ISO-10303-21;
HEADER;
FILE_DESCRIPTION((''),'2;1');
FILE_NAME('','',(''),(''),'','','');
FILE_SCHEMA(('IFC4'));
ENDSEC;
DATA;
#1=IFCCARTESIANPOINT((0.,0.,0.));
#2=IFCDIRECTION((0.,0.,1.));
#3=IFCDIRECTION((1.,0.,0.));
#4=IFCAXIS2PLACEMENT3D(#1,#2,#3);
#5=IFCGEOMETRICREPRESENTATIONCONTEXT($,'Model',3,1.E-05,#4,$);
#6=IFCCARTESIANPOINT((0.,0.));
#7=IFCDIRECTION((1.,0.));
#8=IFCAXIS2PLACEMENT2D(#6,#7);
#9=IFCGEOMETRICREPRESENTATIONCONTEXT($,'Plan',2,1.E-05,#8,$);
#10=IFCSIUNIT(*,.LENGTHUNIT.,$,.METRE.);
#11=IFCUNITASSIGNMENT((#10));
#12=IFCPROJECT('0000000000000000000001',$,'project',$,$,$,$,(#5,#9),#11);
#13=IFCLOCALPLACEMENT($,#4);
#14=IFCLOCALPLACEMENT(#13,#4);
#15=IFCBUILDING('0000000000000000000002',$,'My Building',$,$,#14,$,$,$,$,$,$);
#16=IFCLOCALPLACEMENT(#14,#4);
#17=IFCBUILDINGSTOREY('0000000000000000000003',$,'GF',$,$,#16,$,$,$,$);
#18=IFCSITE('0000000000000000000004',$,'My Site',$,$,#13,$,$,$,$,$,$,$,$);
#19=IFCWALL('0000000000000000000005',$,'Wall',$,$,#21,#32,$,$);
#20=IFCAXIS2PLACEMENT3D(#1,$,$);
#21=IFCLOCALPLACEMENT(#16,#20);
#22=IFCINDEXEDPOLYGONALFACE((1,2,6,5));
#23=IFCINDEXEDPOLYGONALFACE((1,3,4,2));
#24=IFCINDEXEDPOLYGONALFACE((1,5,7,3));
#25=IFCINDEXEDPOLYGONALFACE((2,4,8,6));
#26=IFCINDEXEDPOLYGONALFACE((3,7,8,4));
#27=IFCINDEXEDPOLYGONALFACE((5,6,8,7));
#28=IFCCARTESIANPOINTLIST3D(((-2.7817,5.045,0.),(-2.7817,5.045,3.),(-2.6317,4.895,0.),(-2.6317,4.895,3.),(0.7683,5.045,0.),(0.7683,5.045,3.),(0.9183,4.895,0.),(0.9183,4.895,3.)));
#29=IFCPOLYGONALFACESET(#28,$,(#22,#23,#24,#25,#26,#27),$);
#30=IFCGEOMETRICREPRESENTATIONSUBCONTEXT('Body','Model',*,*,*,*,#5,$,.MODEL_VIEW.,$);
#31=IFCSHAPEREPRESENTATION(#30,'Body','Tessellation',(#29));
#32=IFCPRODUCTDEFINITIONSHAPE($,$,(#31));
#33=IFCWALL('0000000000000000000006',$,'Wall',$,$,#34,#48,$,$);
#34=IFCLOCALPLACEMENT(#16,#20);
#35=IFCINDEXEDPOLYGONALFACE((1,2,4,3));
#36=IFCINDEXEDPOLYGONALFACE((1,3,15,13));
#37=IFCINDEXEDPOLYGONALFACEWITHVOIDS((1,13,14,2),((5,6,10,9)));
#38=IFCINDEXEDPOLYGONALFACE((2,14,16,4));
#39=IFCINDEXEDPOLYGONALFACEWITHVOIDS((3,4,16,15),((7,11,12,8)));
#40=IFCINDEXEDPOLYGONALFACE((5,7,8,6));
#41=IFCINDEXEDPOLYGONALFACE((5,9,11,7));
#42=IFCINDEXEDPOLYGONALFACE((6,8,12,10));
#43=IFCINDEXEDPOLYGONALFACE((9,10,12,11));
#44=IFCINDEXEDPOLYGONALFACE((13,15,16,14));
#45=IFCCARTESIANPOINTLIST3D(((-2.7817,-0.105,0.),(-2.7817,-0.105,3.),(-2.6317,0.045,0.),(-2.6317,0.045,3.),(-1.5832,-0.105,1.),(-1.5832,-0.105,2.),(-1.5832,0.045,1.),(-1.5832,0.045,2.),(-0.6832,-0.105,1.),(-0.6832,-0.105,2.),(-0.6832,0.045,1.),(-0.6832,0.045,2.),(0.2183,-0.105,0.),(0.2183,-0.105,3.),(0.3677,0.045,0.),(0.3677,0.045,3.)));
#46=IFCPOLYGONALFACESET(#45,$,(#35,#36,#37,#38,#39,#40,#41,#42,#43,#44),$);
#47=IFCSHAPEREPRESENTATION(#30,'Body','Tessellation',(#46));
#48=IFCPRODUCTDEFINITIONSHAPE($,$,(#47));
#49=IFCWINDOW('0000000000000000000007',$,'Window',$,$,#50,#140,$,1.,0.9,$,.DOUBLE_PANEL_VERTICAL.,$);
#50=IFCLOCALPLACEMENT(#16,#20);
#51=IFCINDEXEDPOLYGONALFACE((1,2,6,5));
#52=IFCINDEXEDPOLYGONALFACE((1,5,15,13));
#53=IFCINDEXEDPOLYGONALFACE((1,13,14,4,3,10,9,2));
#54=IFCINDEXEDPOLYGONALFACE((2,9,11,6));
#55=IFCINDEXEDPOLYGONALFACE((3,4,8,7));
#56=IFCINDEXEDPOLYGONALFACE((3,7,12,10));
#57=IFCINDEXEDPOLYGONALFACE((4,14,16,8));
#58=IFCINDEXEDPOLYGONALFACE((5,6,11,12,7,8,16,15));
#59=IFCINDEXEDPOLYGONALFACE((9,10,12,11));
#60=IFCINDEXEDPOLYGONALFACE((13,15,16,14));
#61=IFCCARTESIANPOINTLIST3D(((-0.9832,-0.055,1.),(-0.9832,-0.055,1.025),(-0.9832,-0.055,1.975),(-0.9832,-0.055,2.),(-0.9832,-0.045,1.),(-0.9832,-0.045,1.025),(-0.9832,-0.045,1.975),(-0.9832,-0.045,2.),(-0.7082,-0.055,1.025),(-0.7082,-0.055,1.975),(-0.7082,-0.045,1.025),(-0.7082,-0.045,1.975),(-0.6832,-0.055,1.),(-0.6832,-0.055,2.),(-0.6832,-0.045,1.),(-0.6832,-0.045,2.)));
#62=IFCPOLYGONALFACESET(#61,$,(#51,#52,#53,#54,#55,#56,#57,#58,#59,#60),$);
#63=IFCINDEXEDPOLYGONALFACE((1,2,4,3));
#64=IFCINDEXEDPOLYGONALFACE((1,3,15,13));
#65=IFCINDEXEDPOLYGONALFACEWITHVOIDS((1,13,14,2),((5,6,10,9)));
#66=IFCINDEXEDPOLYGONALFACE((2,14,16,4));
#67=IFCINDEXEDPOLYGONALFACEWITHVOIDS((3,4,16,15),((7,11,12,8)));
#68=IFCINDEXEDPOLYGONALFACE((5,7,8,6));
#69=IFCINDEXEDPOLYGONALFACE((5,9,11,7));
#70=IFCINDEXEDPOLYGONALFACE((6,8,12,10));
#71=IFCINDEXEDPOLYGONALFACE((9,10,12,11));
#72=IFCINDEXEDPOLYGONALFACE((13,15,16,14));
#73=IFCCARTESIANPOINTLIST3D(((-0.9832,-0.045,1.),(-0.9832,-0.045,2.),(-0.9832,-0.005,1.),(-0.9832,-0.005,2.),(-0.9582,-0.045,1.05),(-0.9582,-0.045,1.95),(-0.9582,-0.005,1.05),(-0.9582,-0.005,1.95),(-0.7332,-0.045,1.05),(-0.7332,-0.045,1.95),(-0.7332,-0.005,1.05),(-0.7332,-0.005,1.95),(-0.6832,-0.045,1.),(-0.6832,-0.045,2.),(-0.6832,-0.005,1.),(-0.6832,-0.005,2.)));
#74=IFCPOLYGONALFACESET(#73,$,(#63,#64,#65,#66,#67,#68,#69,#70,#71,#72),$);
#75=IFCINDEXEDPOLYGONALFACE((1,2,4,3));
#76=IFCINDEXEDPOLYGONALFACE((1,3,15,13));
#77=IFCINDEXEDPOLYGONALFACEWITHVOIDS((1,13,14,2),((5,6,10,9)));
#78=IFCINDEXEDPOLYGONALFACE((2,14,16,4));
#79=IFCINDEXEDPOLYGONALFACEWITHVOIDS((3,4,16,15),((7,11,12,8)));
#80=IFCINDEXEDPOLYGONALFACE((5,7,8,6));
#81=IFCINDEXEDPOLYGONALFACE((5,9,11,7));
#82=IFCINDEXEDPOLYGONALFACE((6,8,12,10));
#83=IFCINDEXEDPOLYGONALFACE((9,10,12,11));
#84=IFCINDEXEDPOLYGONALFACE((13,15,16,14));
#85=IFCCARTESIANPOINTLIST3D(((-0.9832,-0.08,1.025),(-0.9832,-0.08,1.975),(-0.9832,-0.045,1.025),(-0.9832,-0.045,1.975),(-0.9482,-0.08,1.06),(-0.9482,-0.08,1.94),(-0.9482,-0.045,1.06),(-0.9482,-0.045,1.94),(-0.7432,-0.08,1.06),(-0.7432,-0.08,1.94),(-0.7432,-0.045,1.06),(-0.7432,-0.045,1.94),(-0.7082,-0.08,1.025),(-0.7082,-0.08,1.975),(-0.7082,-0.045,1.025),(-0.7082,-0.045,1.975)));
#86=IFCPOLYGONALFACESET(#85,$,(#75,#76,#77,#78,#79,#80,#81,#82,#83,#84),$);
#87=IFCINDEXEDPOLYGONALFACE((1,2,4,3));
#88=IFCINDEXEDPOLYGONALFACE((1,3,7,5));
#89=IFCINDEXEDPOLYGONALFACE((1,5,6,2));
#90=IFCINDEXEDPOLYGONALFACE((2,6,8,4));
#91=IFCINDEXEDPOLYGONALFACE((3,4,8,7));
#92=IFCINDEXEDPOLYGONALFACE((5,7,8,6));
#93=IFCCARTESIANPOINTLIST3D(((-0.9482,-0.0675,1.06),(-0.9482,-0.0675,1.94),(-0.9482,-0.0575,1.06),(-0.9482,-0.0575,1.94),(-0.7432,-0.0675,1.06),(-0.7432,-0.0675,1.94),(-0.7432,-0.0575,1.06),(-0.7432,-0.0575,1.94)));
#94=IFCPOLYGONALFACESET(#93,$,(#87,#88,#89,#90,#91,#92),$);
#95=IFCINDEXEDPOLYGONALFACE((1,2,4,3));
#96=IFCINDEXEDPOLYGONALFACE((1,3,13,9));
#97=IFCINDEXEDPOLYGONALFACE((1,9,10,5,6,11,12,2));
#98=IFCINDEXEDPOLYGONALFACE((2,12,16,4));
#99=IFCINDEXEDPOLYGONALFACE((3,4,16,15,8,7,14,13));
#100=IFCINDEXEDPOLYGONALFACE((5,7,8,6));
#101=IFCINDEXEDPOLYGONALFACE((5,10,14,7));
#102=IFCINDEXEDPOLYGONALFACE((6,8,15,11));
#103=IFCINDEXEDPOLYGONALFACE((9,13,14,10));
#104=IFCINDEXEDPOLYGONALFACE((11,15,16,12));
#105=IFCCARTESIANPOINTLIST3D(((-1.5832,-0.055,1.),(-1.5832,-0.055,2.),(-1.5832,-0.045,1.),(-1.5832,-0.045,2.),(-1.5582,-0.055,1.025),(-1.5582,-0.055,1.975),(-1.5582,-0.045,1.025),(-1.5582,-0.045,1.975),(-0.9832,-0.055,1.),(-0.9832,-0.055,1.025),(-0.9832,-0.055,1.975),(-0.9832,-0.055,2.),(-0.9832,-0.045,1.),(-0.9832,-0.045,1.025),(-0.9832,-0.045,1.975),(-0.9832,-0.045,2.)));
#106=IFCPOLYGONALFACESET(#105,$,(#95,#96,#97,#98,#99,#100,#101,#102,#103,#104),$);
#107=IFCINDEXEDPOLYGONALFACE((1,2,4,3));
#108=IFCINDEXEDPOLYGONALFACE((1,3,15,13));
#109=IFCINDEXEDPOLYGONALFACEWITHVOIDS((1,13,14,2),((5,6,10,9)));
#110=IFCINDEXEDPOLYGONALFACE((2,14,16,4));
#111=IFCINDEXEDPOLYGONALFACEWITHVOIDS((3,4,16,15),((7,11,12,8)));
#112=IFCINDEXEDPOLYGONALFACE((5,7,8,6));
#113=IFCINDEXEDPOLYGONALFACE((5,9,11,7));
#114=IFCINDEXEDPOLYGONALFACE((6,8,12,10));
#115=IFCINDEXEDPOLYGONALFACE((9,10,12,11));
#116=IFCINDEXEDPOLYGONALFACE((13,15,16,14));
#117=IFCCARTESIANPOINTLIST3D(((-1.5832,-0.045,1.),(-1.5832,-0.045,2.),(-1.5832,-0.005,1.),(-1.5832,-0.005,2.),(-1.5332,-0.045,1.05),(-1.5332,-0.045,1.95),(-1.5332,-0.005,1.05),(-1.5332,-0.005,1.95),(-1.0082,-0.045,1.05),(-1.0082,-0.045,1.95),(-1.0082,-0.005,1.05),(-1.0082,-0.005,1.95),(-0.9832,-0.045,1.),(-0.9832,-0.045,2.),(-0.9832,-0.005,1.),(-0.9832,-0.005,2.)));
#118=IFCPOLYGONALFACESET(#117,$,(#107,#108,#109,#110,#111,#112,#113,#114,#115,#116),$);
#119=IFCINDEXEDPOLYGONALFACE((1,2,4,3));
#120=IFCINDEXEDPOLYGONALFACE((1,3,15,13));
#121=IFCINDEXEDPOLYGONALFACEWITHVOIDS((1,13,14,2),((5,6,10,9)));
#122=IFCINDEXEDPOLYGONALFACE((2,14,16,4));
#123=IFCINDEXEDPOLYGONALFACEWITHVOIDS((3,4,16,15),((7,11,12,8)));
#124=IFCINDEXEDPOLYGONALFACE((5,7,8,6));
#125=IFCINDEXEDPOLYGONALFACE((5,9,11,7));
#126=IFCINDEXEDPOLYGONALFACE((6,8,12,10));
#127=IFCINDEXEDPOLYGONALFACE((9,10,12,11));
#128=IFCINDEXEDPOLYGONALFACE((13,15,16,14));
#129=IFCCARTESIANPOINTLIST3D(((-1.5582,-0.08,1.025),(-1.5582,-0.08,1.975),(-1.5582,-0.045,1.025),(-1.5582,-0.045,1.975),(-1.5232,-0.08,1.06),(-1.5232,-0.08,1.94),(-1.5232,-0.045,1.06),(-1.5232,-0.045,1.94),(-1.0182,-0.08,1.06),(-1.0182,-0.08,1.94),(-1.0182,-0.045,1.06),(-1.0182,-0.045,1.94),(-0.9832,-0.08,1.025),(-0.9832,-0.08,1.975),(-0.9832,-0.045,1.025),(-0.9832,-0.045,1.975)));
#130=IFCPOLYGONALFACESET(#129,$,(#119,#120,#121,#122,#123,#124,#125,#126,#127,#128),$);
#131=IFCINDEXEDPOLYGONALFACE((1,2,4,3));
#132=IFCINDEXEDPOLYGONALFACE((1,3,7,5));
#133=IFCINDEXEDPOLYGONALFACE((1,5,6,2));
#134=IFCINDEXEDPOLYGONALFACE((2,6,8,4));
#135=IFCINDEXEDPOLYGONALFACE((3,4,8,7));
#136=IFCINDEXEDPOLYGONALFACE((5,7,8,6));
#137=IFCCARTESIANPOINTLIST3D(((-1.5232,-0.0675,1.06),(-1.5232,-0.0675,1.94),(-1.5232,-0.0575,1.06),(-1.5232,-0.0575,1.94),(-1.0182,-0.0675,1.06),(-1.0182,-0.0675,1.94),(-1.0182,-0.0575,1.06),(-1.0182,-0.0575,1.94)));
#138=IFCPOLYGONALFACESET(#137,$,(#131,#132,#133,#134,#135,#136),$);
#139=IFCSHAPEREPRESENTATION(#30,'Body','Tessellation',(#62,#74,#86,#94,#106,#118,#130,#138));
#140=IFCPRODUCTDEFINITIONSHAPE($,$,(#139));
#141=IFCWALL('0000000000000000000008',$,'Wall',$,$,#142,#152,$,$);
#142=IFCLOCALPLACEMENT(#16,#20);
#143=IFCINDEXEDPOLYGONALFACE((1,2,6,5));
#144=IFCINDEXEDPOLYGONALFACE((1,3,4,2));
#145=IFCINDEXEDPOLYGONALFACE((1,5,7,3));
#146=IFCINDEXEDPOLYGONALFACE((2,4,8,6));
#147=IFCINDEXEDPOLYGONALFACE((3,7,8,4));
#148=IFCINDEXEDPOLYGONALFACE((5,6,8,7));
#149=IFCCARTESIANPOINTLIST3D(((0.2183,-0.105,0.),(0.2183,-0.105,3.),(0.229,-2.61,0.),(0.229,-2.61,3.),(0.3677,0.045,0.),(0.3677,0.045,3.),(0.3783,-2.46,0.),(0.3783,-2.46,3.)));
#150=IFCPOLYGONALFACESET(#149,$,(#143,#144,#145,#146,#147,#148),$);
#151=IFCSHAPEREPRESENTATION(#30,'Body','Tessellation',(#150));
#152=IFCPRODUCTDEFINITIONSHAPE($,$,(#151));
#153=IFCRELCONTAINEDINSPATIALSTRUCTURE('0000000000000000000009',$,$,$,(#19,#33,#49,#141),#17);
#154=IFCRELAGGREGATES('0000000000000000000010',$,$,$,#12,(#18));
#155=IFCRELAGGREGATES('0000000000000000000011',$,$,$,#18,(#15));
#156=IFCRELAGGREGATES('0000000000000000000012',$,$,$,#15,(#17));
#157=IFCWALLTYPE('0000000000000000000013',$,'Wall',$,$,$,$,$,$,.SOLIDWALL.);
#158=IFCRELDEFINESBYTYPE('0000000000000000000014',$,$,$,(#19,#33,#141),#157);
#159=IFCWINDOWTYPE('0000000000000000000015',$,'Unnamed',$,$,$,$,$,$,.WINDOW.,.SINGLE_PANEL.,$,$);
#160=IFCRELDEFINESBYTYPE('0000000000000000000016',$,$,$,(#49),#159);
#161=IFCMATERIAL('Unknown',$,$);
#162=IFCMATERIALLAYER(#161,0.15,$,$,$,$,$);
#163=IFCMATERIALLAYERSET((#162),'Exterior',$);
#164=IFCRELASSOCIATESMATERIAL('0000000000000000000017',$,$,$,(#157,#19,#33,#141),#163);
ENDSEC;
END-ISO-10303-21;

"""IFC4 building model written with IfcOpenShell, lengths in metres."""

from ifc_helpers import new_model, entity, si_unit, frame, origin_with_axes, origin_2d_with_axis, place, context, subcontext, project, spatial, line, indexed_curve, outline, extrude, shape, source, transform, mapped, material, layer, layer_set, layer_usage, type_object, type_shapes, element, fill, save


model = new_model("IFC4")

# Units and contexts
model_context = context("Model", 3, precision=1e-05, world=origin_with_axes())
plan_context = context("Plan", 2, precision=1e-05, world=origin_2d_with_axis())
body_context_1 = subcontext(model_context, "Body", "Model", "MODEL_VIEW")
body_context_2 = subcontext(plan_context, "Body", "Plan", "PLAN_VIEW")
ifc_project = project(units=[si_unit("LENGTHUNIT", "METRE")], contexts=[model_context, plan_context])

# Site, building, storey
site_placement = place(None, origin_with_axes())
site = spatial("IfcSite", under=ifc_project, at=site_placement, Name="My Site")
building_placement = place(site_placement, origin_with_axes())
building = spatial("IfcBuilding", under=site, at=building_placement, Name="My Building")
storey_placement = place(building_placement, origin_with_axes())
storey = spatial("IfcBuildingStorey", under=building, at=storey_placement, Name="GF")

# Shared definitions
ifc_material = material(Name="Unknown")

# Shared definitions
ifc_layer_1 = layer(ifc_material, 0.15)
ifc_layer_set_1 = layer_set([ifc_layer_1], Name="Exterior")
wall_type_1 = type_object("IfcWallType", Name="Wall", PredefinedType="SOLIDWALL", material=ifc_layer_set_1)

# Wall
ifc_layer_usage_1 = layer_usage(ifc_layer_set_1, "AXIS2", "POSITIVE", 0.0)
wall_1_placement = place(storey_placement, frame((0.7683, 5.045, 0.0), z_axis=(0.0, 0.0, 1.0), x_axis=(-1.0, 0.0, 0.0)))
element("IfcWall", 1, at=wall_1_placement, inside=storey, type_object=wall_type_1, material=ifc_layer_usage_1, Name="Wall", context=body_context_1, shape_type="SweptSolid", body=[
    extrude(outline(indexed_curve([(0.0, 0.0), (-0.15, 0.15), (3.4, 0.15), (3.55, 0.0)], segments=[line(1, 2, 3, 4, 1)])), origin_with_axes(), (0.0, 0.0, 1.0), 3.0),
])

# Shared definitions
shared_shape_1 = source(origin_with_axes(), body_context_1, "Body", "SweptSolid", [
    extrude(outline(indexed_curve([(0.0, 0.0), (0.9, 0.0), (0.9, 1.0), (0.0, 1.0)], segments=[line(1, 2, 3, 4, 1)])), frame((0.0, -0.6, 0.0), z_axis=(0.0, -1.0, 0.0), x_axis=(1.0, 0.0, 0.0)), (0.0, 0.0, -1.0), 1.2),
])
window_type = type_object("IfcWindowType", Name="Unnamed", PartitioningType="SINGLE_PANEL", PredefinedType="WINDOW")
shared_shape_2 = source(origin_with_axes(), body_context_1, "Body", "SweptSolid", [
    extrude(outline(indexed_curve([(0.3, 0.0), (0.0, 0.0), (0.0, 1.0), (0.3, 1.0), (0.3, 0.975), (0.025, 0.975), (0.025, 0.025), (0.3, 0.025)], segments=[line(1, 2, 3, 4, 5, 6, 7, 8, 1)])), frame((0.0, 0.09, 0.0), z_axis=(0.0, -1.0, 0.0), x_axis=(1.0, 0.0, 0.0)), (0.0, 0.0, -1.0), 0.01),
    extrude(outline(indexed_curve([(0.0, 0.0), (0.3, 0.0), (0.3, 1.0), (0.0, 1.0)], segments=[line(1, 2, 3, 4, 1)]), holes=[indexed_curve([(0.05, 0.05), (0.275, 0.05), (0.275, 0.95), (0.05, 0.95)], segments=[line(1, 2, 3, 4, 1)])]), frame((0.0, 0.05, 0.0), z_axis=(0.0, -1.0, 0.0), x_axis=(1.0, 0.0, 0.0)), (0.0, 0.0, -1.0), 0.04),
    extrude(outline(indexed_curve([(0.0, 0.0), (0.275, 0.0), (0.275, 0.95), (0.0, 0.95)], segments=[line(1, 2, 3, 4, 1)]), holes=[indexed_curve([(0.035, 0.035), (0.24, 0.035), (0.24, 0.915), (0.035, 0.915)], segments=[line(1, 2, 3, 4, 1)])]), frame((0.025, 0.09, 0.025), z_axis=(0.0, -1.0, 0.0), x_axis=(1.0, 0.0, 0.0)), (0.0, 0.0, -1.0), 0.035),
    extrude(outline(indexed_curve([(0.035, 0.035), (0.24, 0.035), (0.24, 0.915), (0.035, 0.915)], segments=[line(1, 2, 3, 4, 1)])), frame((0.025, 0.1025, 0.025), z_axis=(0.0, -1.0, 0.0), x_axis=(1.0, 0.0, 0.0)), (0.0, 0.0, -1.0), 0.01),
    extrude(outline(indexed_curve([(0.0, 1.0), (0.6, 1.0), (0.6, 0.0), (0.0, 0.0), (0.0, 0.025), (0.575, 0.025), (0.575, 0.975), (0.0, 0.975)], segments=[line(1, 2, 3, 4, 5, 6, 7, 8, 1)])), frame((0.3, 0.09, 0.0), z_axis=(0.0, -1.0, 0.0), x_axis=(1.0, 0.0, 0.0)), (0.0, 0.0, -1.0), 0.01),
    extrude(outline(indexed_curve([(0.0, 0.0), (0.6, 0.0), (0.6, 1.0), (0.0, 1.0)], segments=[line(1, 2, 3, 4, 1)]), holes=[indexed_curve([(0.025, 0.05), (0.55, 0.05), (0.55, 0.95), (0.025, 0.95)], segments=[line(1, 2, 3, 4, 1)])]), frame((0.3, 0.05, 0.0), z_axis=(0.0, -1.0, 0.0), x_axis=(1.0, 0.0, 0.0)), (0.0, 0.0, -1.0), 0.04),
    extrude(outline(indexed_curve([(0.0, 0.0), (0.575, 0.0), (0.575, 0.95), (0.0, 0.95)], segments=[line(1, 2, 3, 4, 1)]), holes=[indexed_curve([(0.035, 0.035), (0.54, 0.035), (0.54, 0.915), (0.035, 0.915)], segments=[line(1, 2, 3, 4, 1)])]), frame((0.3, 0.09, 0.025), z_axis=(0.0, -1.0, 0.0), x_axis=(1.0, 0.0, 0.0)), (0.0, 0.0, -1.0), 0.035),
    extrude(outline(indexed_curve([(0.035, 0.035), (0.54, 0.035), (0.54, 0.915), (0.035, 0.915)], segments=[line(1, 2, 3, 4, 1)])), frame((0.3, 0.1025, 0.025), z_axis=(0.0, -1.0, 0.0), x_axis=(1.0, 0.0, 0.0)), (0.0, 0.0, -1.0), 0.01),
])
shared_shape_3 = source(origin_with_axes(), body_context_2, "Body", "Curve2D", [
    entity("IfcIndexedPolyCurve", entity("IfcCartesianPointList2D", [[0.05, 0.05], [0.275, 0.05]])),
    entity("IfcIndexedPolyCurve", entity("IfcCartesianPointList2D", [[0.0, 0.1], [0.025, 0.1], [0.025, 0.09], [0.05, 0.09], [0.05, 0.05], [0.0, 0.05]]), [entity("IfcLineIndex", [1, 2, 3, 4, 5, 6, 1])]),
    entity("IfcIndexedPolyCurve", entity("IfcCartesianPointList2D", [[0.3, 0.1], [0.3, 0.1], [0.3, 0.09], [0.275, 0.09], [0.275, 0.05], [0.3, 0.05]])),
    entity("IfcIndexedPolyCurve", entity("IfcCartesianPointList2D", [[0.025, 0.09], [0.06, 0.09], [0.06, 0.125], [0.025, 0.125]]), [entity("IfcLineIndex", [1, 2, 3, 4, 1])]),
    entity("IfcIndexedPolyCurve", entity("IfcCartesianPointList2D", [[0.3, 0.09], [0.265, 0.09], [0.265, 0.125], [0.3, 0.125]]), [entity("IfcLineIndex", [1, 2, 3, 4, 1])]),
    entity("IfcIndexedPolyCurve", entity("IfcCartesianPointList2D", [[0.06, 0.09], [0.265, 0.09]])),
    entity("IfcIndexedPolyCurve", entity("IfcCartesianPointList2D", [[0.06, 0.125], [0.265, 0.125]])),
    entity("IfcIndexedPolyCurve", entity("IfcCartesianPointList2D", [[0.06, 0.1075], [0.265, 0.1075]])),
    entity("IfcIndexedPolyCurve", entity("IfcCartesianPointList2D", [[0.325, 0.05], [0.85, 0.05]])),
    entity("IfcIndexedPolyCurve", entity("IfcCartesianPointList2D", [[0.3, 0.1], [0.3, 0.1], [0.3, 0.09], [0.325, 0.09], [0.325, 0.05], [0.3, 0.05]])),
    entity("IfcIndexedPolyCurve", entity("IfcCartesianPointList2D", [[0.9, 0.1], [0.875, 0.1], [0.875, 0.09], [0.85, 0.09], [0.85, 0.05], [0.9, 0.05]]), [entity("IfcLineIndex", [1, 2, 3, 4, 5, 6, 1])]),
    entity("IfcIndexedPolyCurve", entity("IfcCartesianPointList2D", [[0.3, 0.09], [0.335, 0.09], [0.335, 0.125], [0.3, 0.125]]), [entity("IfcLineIndex", [1, 2, 3, 4, 1])]),
    entity("IfcIndexedPolyCurve", entity("IfcCartesianPointList2D", [[0.875, 0.09], [0.84, 0.09], [0.84, 0.125], [0.875, 0.125]]), [entity("IfcLineIndex", [1, 2, 3, 4, 1])]),
    entity("IfcIndexedPolyCurve", entity("IfcCartesianPointList2D", [[0.335, 0.09], [0.84, 0.09]])),
    entity("IfcIndexedPolyCurve", entity("IfcCartesianPointList2D", [[0.335, 0.125], [0.84, 0.125]])),
    entity("IfcIndexedPolyCurve", entity("IfcCartesianPointList2D", [[0.335, 0.1075], [0.84, 0.1075]])),
])
type_shapes(window_type, [shared_shape_2, shared_shape_3])

# Wall, opening, window
ifc_layer_usage_2 = layer_usage(ifc_layer_set_1, "AXIS2", "POSITIVE", 0.0)
wall_2_placement = place(storey_placement, frame((-2.7817, -0.105, 0.0), z_axis=(0.0, 0.0, 1.0), x_axis=(1.0, 0.0, 0.0)))
wall_2 = element("IfcWall", 2, at=wall_2_placement, inside=storey, type_object=wall_type_1, material=ifc_layer_usage_2, Name="Wall", context=body_context_1, shape_type="SweptSolid", body=[
    extrude(outline(indexed_curve([(0.0, 0.0), (0.15, 0.15), (3.1494, 0.15), (3.0, 0.0)], segments=[line(1, 2, 3, 4, 1)])), origin_with_axes(), (0.0, 0.0, 1.0), 3.0),
])
opening_1_placement = place(wall_2_placement, frame((2.0985, 0.15, 1.0), z_axis=(0.0, 0.0, 1.0), x_axis=(-1.0, 0.0, 0.0)))
opening_1 = element("IfcOpeningElement", 3, at=opening_1_placement, cuts=wall_2, PredefinedType="OPENING", context=body_context_1, shape_type="MappedRepresentation", body=[
    mapped(shared_shape_1, transform((0.0, 0.0, 0.0), x_axis=(1.0, 0.0, 0.0), y_axis=(0.0, 1.0, 0.0), z_axis=(0.0, 0.0, 1.0), scale=1.0)),
])
window_1_placement = place(opening_1_placement, origin_with_axes())
window_1 = element("IfcWindow", 4, at=window_1_placement, inside=storey, type_object=window_type, Name="Window", OverallHeight=1.0, OverallWidth=0.9, PartitioningType="DOUBLE_PANEL_VERTICAL", shapes=[
    shape(body_context_1, "Body", "MappedRepresentation", [mapped(shared_shape_2, transform((0.0, 0.0, 0.0), x_axis=(1.0, 0.0, 0.0), y_axis=(0.0, 1.0, 0.0), z_axis=(0.0, 0.0, 1.0), scale=1.0))]),
    shape(body_context_2, "Body", "MappedRepresentation", [mapped(shared_shape_3, transform((0.0, 0.0, 0.0), x_axis=(1.0, 0.0, 0.0), y_axis=(0.0, 1.0, 0.0), z_axis=(0.0, 0.0, 1.0), scale=1.0))]),
])
fill(opening_1, window_1)

# Wall
ifc_layer_usage_3 = layer_usage(ifc_layer_set_1, "AXIS2", "POSITIVE", 0.0)
wall_3_placement = place(storey_placement, frame((0.2183, -0.105, 0.0), z_axis=(0.0, 0.0, 1.0), x_axis=(0.004245, -0.999991, 0.0)))
element("IfcWall", 5, at=wall_3_placement, inside=storey, type_object=wall_type_1, material=ifc_layer_usage_3, Name="Wall", context=body_context_1, shape_type="SweptSolid", body=[
    extrude(outline(indexed_curve([(0.0, 0.0), (-0.1494, 0.15), (2.3557, 0.15), (2.505, 0.0)], segments=[line(1, 2, 3, 4, 1)])), origin_with_axes(), (0.0, 0.0, 1.0), 3.0),
])

save(model, "model.ifc")
